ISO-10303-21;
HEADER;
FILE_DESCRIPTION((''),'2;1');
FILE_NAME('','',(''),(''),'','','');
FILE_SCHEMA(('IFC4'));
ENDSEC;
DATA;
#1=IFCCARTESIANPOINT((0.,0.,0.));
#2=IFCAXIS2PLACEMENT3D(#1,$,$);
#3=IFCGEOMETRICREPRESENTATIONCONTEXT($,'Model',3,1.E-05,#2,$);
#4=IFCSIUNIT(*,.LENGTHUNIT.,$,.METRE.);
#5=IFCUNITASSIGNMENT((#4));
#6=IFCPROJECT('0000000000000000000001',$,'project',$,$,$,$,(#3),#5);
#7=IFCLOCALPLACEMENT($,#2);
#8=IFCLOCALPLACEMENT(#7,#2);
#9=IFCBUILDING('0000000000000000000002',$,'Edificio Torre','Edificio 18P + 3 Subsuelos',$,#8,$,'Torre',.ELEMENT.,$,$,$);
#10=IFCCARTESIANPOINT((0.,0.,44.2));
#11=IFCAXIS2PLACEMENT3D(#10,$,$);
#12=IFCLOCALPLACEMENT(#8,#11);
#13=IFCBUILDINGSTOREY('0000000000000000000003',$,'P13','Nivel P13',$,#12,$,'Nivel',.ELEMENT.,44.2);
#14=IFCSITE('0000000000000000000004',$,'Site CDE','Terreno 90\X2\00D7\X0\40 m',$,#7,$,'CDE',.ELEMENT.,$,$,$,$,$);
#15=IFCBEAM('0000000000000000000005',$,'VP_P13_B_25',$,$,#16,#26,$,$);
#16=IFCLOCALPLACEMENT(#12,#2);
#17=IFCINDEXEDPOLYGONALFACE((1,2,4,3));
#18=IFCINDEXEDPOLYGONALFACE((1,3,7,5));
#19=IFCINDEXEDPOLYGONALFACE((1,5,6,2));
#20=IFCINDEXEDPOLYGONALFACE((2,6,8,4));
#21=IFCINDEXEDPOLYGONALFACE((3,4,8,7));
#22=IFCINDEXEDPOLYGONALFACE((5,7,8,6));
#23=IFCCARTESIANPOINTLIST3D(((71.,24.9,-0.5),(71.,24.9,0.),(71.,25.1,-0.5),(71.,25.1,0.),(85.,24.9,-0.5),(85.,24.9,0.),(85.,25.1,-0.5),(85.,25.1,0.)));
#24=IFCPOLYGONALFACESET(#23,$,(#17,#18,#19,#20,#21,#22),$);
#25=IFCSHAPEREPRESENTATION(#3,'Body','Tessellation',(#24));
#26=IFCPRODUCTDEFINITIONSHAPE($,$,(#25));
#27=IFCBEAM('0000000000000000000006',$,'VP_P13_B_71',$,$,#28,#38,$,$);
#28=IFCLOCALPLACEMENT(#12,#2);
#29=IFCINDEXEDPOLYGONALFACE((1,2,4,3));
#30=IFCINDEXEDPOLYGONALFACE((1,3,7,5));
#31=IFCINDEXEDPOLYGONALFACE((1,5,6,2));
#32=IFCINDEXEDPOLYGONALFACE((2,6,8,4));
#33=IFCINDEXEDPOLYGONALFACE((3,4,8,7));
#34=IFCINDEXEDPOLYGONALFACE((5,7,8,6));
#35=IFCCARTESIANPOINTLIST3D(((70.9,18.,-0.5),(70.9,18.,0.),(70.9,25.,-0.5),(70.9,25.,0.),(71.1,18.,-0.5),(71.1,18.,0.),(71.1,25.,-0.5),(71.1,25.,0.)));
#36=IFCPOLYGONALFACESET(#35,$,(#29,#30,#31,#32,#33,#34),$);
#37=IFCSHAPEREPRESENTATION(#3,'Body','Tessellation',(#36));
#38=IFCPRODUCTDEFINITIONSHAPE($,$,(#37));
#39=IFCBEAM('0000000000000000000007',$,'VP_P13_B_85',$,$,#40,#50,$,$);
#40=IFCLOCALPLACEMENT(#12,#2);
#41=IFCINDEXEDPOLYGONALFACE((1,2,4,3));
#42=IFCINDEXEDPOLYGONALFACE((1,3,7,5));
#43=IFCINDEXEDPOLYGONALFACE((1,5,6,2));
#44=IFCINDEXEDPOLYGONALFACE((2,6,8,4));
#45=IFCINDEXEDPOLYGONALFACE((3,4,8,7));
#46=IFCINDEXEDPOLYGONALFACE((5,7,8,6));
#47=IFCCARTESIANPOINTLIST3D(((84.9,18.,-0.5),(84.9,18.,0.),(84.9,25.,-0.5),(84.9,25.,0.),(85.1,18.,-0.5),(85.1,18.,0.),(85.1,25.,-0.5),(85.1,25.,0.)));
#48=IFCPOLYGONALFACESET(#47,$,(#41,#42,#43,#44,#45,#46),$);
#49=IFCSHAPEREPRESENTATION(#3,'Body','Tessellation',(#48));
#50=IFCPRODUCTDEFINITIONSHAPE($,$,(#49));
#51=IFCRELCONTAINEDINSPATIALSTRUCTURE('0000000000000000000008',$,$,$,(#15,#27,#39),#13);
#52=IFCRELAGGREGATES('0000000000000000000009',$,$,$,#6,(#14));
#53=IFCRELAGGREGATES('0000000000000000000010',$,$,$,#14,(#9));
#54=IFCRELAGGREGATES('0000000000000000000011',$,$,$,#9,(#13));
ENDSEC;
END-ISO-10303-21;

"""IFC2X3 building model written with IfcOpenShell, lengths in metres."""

from ifc_helpers import new_model, si_unit, frame, origin, origin_2d, place, context, project, spatial, rectangle, extrude, element, save


model = new_model("IFC2X3")

# Units and contexts
model_context = context("Model", 3, precision=1e-05, world=origin())
ifc_project = project(units=[si_unit("LENGTHUNIT", "METRE")], contexts=[model_context])

# Site, building, storey
site_placement = place(None, origin())
site = spatial("IfcSite", under=ifc_project, at=site_placement, Name="Site CDE", Description="Terreno 90×40 m", LongName="CDE", CompositionType="ELEMENT")
building_placement = place(site_placement, origin())
building = spatial("IfcBuilding", under=site, at=building_placement, Name="Edificio Torre", Description="Edificio 18P + 3 Subsuelos", LongName="Torre", CompositionType="ELEMENT")
storey_placement = place(building_placement, frame((0.0, 0.0, 44.2)))
storey = spatial("IfcBuildingStorey", under=building, at=storey_placement, Name="P13", Description="Nivel P13", LongName="Nivel", CompositionType="ELEMENT", Elevation=44.2)

# Beams
for number, where, name in (
    (1, (78.0, 25.0, -0.5), "VP_P13_B_25"),
):
    element("IfcBeam", number, at=place(storey_placement, frame(where)), inside=storey, Name=name, context=model_context, shape_type="SweptSolid", body=[
        extrude(rectangle(XDim=14.0, YDim=0.2, at=origin_2d()), origin(), (0.0, 0.0, 1.0), 0.5),
    ])
for number, where, name in (
    (2, (71.0, 21.5, -0.5), "VP_P13_B_71"),
    (3, (85.0, 21.5, -0.5), "VP_P13_B_85"),
):
    element("IfcBeam", number, at=place(storey_placement, frame(where)), inside=storey, Name=name, context=model_context, shape_type="SweptSolid", body=[
        extrude(rectangle(XDim=0.2, YDim=7.0, at=origin_2d()), origin(), (0.0, 0.0, 1.0), 0.5),
    ])

save(model, "model.ifc")
